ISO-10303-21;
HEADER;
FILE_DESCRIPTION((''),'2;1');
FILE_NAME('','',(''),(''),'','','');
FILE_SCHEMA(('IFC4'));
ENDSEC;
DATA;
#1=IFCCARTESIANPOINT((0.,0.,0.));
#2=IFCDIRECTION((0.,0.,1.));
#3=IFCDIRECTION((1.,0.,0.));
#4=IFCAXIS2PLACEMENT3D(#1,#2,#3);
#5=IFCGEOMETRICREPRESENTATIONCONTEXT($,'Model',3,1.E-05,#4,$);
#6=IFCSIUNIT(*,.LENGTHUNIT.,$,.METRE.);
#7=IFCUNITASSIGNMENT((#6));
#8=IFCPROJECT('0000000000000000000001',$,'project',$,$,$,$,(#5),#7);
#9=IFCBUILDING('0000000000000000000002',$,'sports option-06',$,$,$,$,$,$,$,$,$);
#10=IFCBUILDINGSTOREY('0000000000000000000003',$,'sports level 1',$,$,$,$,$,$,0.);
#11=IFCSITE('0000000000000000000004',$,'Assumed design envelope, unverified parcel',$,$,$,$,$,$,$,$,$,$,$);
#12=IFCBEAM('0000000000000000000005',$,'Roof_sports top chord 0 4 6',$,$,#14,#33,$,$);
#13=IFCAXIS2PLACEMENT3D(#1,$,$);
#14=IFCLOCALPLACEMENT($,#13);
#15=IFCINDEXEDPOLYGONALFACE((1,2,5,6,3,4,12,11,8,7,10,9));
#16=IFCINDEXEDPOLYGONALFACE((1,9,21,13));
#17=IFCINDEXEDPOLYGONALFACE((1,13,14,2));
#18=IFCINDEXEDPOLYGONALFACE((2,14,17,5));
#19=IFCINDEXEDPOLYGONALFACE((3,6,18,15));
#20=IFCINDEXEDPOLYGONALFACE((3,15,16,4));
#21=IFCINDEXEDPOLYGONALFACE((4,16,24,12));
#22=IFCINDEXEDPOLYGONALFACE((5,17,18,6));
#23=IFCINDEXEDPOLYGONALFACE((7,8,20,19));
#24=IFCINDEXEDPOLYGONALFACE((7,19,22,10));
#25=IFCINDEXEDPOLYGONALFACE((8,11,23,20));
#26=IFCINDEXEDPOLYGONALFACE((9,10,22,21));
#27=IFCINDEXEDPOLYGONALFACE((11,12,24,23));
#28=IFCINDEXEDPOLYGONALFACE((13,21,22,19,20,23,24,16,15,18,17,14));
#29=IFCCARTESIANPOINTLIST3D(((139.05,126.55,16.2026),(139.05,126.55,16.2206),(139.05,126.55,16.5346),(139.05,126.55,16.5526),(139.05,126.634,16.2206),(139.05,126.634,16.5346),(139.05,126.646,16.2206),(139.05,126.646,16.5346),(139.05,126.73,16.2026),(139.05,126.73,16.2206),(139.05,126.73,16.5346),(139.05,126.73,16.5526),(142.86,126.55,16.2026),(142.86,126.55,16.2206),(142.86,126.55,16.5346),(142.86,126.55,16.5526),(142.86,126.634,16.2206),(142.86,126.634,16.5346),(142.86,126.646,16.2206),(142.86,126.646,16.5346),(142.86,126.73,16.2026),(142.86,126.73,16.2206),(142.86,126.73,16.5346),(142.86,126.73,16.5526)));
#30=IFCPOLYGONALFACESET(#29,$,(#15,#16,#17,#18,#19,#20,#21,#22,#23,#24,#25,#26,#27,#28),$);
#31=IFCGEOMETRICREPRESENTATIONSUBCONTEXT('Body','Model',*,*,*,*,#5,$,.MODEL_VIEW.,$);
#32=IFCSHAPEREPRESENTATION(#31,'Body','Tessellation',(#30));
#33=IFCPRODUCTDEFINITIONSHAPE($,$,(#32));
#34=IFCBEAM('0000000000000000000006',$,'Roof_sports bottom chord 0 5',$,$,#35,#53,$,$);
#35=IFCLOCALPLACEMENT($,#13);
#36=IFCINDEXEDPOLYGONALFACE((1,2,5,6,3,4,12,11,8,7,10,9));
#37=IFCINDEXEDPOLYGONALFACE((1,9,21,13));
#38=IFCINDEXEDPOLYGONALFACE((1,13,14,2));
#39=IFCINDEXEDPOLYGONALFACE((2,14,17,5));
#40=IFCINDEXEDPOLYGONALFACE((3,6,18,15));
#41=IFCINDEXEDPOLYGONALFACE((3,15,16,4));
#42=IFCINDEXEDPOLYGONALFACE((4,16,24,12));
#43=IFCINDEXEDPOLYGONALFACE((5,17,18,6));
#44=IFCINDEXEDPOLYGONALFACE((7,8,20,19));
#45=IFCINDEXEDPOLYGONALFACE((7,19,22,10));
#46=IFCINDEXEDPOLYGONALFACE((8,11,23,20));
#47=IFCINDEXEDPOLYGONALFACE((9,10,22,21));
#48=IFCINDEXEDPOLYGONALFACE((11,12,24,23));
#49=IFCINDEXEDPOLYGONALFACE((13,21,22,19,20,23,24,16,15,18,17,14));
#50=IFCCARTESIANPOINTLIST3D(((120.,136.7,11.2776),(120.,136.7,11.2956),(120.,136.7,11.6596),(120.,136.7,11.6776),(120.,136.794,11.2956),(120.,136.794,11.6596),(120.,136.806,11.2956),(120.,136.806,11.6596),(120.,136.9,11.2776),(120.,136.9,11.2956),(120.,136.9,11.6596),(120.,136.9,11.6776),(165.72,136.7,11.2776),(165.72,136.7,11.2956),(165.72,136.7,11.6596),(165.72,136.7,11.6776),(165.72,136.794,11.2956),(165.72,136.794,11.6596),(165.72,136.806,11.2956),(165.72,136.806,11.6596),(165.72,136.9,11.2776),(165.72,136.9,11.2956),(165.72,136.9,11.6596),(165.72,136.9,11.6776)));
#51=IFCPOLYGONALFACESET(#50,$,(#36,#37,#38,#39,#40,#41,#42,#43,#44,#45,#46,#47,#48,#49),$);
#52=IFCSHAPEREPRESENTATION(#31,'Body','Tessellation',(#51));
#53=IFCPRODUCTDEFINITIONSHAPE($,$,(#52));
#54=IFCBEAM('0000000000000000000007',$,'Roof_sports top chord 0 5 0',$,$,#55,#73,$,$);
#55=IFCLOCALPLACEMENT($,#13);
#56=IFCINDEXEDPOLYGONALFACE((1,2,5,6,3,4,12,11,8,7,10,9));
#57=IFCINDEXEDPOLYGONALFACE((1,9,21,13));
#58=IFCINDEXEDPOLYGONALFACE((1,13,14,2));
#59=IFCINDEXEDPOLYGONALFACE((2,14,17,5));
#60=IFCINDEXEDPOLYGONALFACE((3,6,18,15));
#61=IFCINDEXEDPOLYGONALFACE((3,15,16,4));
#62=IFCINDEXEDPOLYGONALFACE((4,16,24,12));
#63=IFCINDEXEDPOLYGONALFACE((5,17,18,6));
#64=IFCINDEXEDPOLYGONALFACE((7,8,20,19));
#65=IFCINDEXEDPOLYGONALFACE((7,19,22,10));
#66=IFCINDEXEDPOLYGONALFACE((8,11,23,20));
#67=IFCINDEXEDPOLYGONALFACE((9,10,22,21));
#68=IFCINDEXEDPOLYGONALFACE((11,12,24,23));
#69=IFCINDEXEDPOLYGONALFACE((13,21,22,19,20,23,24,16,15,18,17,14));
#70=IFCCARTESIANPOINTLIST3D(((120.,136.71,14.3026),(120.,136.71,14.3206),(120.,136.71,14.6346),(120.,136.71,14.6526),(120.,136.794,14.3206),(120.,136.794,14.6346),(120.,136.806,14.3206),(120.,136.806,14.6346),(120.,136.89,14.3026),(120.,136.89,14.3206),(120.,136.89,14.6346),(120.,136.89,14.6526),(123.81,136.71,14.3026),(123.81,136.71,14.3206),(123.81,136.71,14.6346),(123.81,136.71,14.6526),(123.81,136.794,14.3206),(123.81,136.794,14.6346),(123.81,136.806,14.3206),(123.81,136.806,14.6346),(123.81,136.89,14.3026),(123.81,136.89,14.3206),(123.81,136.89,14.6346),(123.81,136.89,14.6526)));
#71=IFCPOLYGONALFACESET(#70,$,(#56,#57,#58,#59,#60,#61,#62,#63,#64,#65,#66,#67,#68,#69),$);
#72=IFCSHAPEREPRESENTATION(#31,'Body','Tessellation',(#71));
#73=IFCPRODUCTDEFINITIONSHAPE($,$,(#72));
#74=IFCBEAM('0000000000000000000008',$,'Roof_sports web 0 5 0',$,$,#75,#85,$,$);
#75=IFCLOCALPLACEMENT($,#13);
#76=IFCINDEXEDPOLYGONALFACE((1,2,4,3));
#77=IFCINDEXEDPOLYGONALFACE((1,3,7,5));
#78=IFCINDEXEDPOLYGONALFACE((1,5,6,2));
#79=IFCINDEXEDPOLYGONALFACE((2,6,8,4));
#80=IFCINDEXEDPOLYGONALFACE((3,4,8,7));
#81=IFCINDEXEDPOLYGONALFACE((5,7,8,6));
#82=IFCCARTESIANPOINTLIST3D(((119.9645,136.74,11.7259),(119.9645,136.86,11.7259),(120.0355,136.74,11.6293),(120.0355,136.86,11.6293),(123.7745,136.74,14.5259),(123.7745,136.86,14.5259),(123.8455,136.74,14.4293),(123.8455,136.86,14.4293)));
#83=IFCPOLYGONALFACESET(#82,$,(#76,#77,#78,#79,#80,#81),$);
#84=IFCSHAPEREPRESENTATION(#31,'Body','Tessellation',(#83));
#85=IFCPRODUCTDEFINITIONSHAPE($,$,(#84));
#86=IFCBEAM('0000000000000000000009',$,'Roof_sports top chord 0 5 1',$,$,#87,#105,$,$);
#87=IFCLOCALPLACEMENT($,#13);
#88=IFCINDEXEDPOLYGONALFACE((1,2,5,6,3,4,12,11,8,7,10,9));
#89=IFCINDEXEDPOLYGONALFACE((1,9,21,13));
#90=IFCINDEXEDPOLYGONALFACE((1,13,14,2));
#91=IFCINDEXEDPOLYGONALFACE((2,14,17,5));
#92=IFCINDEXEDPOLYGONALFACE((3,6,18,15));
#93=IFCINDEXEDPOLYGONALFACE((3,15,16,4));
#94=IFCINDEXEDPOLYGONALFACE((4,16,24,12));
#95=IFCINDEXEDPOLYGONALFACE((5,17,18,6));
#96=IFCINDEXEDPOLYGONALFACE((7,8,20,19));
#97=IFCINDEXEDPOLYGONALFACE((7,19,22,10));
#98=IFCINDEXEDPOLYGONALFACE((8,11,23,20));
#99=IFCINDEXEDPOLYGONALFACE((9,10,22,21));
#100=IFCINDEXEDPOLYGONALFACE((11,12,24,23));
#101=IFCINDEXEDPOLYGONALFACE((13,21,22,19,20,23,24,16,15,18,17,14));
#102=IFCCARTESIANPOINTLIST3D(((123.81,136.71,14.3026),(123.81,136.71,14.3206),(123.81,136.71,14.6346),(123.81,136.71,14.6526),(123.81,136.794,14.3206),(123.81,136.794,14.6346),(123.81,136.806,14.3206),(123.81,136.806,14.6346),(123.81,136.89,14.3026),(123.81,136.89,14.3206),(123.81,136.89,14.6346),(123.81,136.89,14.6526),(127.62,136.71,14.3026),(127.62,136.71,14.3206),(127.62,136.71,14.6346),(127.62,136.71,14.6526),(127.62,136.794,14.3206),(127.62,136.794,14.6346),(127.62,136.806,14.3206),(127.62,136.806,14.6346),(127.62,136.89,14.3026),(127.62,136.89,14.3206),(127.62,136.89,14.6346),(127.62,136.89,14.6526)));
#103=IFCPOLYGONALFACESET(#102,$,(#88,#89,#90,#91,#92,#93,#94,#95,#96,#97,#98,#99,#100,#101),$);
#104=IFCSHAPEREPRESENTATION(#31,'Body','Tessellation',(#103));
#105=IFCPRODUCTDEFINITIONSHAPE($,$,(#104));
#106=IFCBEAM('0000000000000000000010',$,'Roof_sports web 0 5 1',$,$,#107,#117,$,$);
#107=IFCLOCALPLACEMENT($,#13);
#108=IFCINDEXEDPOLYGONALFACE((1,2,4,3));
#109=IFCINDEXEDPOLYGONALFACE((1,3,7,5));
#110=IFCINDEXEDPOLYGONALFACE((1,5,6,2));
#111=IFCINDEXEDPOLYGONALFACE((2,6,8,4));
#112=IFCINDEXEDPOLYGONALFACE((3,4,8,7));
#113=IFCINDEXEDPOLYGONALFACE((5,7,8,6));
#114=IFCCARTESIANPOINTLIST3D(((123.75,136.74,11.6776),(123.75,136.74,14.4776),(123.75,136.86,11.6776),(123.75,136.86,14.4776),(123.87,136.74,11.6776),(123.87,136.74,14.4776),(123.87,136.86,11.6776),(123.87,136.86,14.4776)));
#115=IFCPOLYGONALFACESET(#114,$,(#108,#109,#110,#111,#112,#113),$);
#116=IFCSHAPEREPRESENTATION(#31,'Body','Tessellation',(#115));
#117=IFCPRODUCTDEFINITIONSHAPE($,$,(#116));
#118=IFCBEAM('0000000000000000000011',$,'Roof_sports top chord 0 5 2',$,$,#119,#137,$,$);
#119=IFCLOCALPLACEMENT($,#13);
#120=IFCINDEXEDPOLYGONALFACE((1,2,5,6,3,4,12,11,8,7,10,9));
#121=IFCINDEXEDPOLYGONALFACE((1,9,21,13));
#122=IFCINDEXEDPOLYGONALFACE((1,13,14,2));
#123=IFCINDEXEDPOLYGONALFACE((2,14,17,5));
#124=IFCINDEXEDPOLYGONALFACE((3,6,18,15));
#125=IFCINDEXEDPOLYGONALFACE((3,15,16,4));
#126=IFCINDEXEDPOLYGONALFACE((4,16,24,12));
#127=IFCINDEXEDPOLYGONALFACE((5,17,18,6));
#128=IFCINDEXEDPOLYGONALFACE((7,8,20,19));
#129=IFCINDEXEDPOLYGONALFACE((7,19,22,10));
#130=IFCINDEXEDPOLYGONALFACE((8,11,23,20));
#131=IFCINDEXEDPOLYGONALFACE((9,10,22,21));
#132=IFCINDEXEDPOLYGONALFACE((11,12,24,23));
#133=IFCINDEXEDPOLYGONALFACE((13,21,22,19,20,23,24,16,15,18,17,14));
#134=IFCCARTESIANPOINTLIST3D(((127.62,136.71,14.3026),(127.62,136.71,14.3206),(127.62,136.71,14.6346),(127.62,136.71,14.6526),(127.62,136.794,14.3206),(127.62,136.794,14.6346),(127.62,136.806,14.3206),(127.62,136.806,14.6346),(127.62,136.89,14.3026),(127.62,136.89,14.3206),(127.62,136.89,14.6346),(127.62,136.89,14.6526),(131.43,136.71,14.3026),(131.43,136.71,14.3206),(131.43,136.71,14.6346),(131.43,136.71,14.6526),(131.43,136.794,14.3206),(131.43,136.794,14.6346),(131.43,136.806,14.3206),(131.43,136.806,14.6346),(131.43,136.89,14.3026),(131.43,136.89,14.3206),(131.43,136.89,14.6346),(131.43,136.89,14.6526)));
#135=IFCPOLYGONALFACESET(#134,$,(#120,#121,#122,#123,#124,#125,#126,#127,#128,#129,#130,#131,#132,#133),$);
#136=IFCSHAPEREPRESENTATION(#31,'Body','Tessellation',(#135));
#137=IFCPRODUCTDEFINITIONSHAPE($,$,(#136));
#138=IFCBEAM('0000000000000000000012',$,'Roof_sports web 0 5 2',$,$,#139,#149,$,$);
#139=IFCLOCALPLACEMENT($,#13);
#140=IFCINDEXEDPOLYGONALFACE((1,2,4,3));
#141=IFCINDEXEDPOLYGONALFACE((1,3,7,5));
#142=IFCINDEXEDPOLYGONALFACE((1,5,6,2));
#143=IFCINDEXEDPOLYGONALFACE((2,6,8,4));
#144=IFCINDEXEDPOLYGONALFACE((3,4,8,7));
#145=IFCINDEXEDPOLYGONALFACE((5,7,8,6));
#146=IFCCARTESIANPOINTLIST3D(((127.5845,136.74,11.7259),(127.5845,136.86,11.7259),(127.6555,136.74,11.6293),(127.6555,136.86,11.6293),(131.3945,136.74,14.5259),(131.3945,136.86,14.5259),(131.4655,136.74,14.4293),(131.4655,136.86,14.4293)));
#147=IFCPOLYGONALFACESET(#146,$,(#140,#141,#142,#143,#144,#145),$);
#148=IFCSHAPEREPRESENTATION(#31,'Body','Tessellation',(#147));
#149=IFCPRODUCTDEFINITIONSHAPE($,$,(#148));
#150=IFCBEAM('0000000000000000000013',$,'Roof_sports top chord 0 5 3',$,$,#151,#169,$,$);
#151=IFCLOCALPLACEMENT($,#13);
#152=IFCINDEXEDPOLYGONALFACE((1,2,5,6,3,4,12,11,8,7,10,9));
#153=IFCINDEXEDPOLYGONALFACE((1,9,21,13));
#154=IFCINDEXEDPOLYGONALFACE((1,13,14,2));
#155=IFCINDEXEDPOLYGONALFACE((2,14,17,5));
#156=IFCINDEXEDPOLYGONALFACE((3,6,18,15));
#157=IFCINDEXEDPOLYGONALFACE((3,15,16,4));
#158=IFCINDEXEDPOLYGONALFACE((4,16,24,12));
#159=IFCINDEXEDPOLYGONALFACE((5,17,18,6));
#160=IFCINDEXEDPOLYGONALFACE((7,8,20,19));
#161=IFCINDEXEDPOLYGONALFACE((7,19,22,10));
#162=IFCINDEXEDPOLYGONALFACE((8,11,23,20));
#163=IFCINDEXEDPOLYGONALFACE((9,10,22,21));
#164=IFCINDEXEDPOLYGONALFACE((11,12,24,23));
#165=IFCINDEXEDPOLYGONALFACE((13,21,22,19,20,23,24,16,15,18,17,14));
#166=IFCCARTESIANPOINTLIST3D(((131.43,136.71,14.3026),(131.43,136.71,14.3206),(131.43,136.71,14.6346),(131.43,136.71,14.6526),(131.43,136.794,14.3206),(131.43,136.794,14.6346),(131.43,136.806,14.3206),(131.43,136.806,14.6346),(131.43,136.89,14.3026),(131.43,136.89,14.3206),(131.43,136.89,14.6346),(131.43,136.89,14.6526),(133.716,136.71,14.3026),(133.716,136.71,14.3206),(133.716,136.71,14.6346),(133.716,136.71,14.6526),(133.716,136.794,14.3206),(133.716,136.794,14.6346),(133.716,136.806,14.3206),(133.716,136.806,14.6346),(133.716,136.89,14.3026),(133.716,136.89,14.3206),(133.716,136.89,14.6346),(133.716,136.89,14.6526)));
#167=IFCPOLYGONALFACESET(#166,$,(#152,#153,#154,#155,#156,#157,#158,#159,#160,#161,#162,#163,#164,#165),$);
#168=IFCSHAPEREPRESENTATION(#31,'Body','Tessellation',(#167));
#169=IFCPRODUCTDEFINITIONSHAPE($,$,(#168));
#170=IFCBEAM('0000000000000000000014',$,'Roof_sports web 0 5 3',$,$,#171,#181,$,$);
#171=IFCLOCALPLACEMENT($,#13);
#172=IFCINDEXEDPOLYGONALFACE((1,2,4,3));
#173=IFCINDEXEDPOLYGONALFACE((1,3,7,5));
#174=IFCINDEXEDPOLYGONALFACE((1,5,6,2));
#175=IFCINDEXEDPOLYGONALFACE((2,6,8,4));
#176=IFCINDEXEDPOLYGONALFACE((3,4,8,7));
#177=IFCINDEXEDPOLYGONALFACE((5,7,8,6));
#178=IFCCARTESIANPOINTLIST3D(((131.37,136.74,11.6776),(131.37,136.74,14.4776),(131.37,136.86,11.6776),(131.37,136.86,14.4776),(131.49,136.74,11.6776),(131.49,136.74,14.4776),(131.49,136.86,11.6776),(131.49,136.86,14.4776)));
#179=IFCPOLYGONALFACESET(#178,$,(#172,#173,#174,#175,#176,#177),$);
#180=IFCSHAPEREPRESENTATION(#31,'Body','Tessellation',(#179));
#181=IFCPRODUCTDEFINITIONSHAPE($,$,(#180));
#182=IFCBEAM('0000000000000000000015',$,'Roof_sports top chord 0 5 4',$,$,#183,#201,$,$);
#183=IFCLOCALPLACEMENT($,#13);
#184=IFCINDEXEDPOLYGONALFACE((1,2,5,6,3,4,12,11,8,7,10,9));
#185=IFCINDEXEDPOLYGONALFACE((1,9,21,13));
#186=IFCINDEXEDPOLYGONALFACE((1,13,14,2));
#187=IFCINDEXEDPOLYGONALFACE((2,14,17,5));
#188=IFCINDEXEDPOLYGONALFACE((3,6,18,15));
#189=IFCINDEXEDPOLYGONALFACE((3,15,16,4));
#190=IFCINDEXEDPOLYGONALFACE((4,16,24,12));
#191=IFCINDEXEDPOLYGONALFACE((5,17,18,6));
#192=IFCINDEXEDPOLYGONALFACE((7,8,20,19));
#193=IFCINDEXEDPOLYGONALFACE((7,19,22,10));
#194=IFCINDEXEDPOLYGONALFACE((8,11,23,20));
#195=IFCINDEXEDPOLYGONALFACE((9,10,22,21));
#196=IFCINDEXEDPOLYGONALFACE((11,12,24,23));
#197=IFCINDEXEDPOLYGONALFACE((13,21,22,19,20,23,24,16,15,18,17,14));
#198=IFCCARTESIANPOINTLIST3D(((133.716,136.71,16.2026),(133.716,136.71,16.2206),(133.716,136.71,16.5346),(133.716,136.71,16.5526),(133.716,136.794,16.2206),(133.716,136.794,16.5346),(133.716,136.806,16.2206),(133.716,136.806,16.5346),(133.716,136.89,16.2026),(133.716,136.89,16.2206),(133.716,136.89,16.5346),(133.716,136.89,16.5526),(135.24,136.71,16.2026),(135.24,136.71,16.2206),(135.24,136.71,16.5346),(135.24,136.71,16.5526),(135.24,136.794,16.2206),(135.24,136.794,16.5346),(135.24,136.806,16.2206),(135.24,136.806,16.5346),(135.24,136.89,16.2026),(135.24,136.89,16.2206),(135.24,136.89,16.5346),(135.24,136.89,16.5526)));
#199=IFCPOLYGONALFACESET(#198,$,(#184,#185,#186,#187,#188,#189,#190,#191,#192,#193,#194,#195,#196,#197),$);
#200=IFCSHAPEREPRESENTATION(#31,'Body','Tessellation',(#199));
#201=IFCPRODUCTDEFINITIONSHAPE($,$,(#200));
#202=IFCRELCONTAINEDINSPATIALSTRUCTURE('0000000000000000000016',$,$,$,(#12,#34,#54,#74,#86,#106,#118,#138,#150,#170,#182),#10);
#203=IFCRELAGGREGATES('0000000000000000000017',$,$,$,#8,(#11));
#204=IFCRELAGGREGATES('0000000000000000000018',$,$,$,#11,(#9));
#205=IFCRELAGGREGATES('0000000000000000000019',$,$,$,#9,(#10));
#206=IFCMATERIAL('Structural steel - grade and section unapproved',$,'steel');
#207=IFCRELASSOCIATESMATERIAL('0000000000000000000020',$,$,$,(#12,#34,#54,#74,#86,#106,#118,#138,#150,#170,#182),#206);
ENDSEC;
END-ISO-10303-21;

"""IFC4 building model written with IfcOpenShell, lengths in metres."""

from ifc_helpers import new_model, si_unit, frame, origin_with_axes, place, context, subcontext, project, spatial, rectangle, i_section, extrude, material, element, save


model = new_model("IFC4")

# Units and contexts
model_context = context("Model", 3, precision=1e-05, world=origin_with_axes())
body_context = subcontext(model_context, "Body", "Model", "MODEL_VIEW")
ifc_project = project(units=[si_unit("LENGTHUNIT", "METRE")], contexts=[model_context])

# Site, building, storey
site = spatial("IfcSite", under=ifc_project, Name="Assumed design envelope, unverified parcel")
building = spatial("IfcBuilding", under=site, Name="sports option-06")
storey = spatial("IfcBuildingStorey", under=building, Name="sports level 1", Elevation=0.0)

# Shared definitions
ifc_material_1 = material(Name="Structural steel - grade and section unapproved", Category="steel")

# Beams
beam_1_placement = place(None, frame((139.05, 126.64, 16.3776), z_axis=(1.0, 0.0, 0.0), x_axis=(0.0, 1.0, 0.0)))
element("IfcBeam", 1, at=beam_1_placement, inside=storey, material=ifc_material_1, Name="Roof_sports top chord 0 4 6", context=body_context, shape_type="SweptSolid", body=[
    extrude(i_section(OverallWidth=0.18, OverallDepth=0.35, WebThickness=0.012, FlangeThickness=0.018, FilletRadius=0.0), origin_with_axes(), (0.0, 0.0, 1.0), 3.81),
])
beam_2_placement = place(None, frame((120.0, 136.8, 11.4776), z_axis=(1.0, 0.0, 0.0), x_axis=(0.0, 1.0, 0.0)))
element("IfcBeam", 2, at=beam_2_placement, inside=storey, material=ifc_material_1, Name="Roof_sports bottom chord 0 5", context=body_context, shape_type="SweptSolid", body=[
    extrude(i_section(OverallWidth=0.2, OverallDepth=0.4, WebThickness=0.012, FlangeThickness=0.018, FilletRadius=0.0), origin_with_axes(), (0.0, 0.0, 1.0), 45.72),
])
beam_3_placement = place(None, frame((120.0, 136.8, 14.4776), z_axis=(1.0, 0.0, 0.0), x_axis=(0.0, 1.0, 0.0)))
element("IfcBeam", 3, at=beam_3_placement, inside=storey, material=ifc_material_1, Name="Roof_sports top chord 0 5 0", context=body_context, shape_type="SweptSolid", body=[
    extrude(i_section(OverallWidth=0.18, OverallDepth=0.35, WebThickness=0.012, FlangeThickness=0.018, FilletRadius=0.0), origin_with_axes(), (0.0, 0.0, 1.0), 3.81),
])
beam_4_placement = place(None, frame((120.0, 136.8, 11.6776), z_axis=(0.805799, 0.0, 0.592189), x_axis=(0.0, 1.0, 0.0)))
element("IfcBeam", 4, at=beam_4_placement, inside=storey, material=ifc_material_1, Name="Roof_sports web 0 5 0", context=body_context, shape_type="SweptSolid", body=[
    extrude(rectangle(XDim=0.12, YDim=0.12), origin_with_axes(), (0.0, 0.0, 1.0), 4.7282),
])
beam_5_placement = place(None, frame((123.81, 136.8, 14.4776), z_axis=(1.0, 0.0, 0.0), x_axis=(0.0, 1.0, 0.0)))
element("IfcBeam", 5, at=beam_5_placement, inside=storey, material=ifc_material_1, Name="Roof_sports top chord 0 5 1", context=body_context, shape_type="SweptSolid", body=[
    extrude(i_section(OverallWidth=0.18, OverallDepth=0.35, WebThickness=0.012, FlangeThickness=0.018, FilletRadius=0.0), origin_with_axes(), (0.0, 0.0, 1.0), 3.81),
])
beam_6_placement = place(None, frame((123.81, 136.8, 11.6776), z_axis=(0.0, 0.0, 1.0), x_axis=(-1.0, 0.0, 0.0)))
element("IfcBeam", 6, at=beam_6_placement, inside=storey, material=ifc_material_1, Name="Roof_sports web 0 5 1", context=body_context, shape_type="SweptSolid", body=[
    extrude(rectangle(XDim=0.12, YDim=0.12), origin_with_axes(), (0.0, 0.0, 1.0), 2.8),
])
beam_7_placement = place(None, frame((127.62, 136.8, 14.4776), z_axis=(1.0, 0.0, 0.0), x_axis=(0.0, 1.0, 0.0)))
element("IfcBeam", 7, at=beam_7_placement, inside=storey, material=ifc_material_1, Name="Roof_sports top chord 0 5 2", context=body_context, shape_type="SweptSolid", body=[
    extrude(i_section(OverallWidth=0.18, OverallDepth=0.35, WebThickness=0.012, FlangeThickness=0.018, FilletRadius=0.0), origin_with_axes(), (0.0, 0.0, 1.0), 3.81),
])
beam_8_placement = place(None, frame((127.62, 136.8, 11.6776), z_axis=(0.805799, 0.0, 0.59219), x_axis=(0.0, 1.0, 0.0)))
element("IfcBeam", 8, at=beam_8_placement, inside=storey, material=ifc_material_1, Name="Roof_sports web 0 5 2", context=body_context, shape_type="SweptSolid", body=[
    extrude(rectangle(XDim=0.12, YDim=0.12), origin_with_axes(), (0.0, 0.0, 1.0), 4.7282),
])
beam_9_placement = place(None, frame((131.43, 136.8, 14.4776), z_axis=(1.0, 0.0, 0.0), x_axis=(0.0, 1.0, 0.0)))
element("IfcBeam", 9, at=beam_9_placement, inside=storey, material=ifc_material_1, Name="Roof_sports top chord 0 5 3", context=body_context, shape_type="SweptSolid", body=[
    extrude(i_section(OverallWidth=0.18, OverallDepth=0.35, WebThickness=0.012, FlangeThickness=0.018, FilletRadius=0.0), origin_with_axes(), (0.0, 0.0, 1.0), 2.286),
])
beam_10_placement = place(None, frame((131.43, 136.8, 11.6776), z_axis=(0.0, 0.0, 1.0), x_axis=(-1.0, 0.0, 0.0)))
element("IfcBeam", 10, at=beam_10_placement, inside=storey, material=ifc_material_1, Name="Roof_sports web 0 5 3", context=body_context, shape_type="SweptSolid", body=[
    extrude(rectangle(XDim=0.12, YDim=0.12), origin_with_axes(), (0.0, 0.0, 1.0), 2.8),
])
beam_11_placement = place(None, frame((133.716, 136.8, 16.3776), z_axis=(1.0, 0.0, 0.0), x_axis=(0.0, 1.0, 0.0)))
element("IfcBeam", 11, at=beam_11_placement, inside=storey, material=ifc_material_1, Name="Roof_sports top chord 0 5 4", context=body_context, shape_type="SweptSolid", body=[
    extrude(i_section(OverallWidth=0.18, OverallDepth=0.35, WebThickness=0.012, FlangeThickness=0.018, FilletRadius=0.0), origin_with_axes(), (0.0, 0.0, 1.0), 1.524),
])

save(model, "model.ifc")
